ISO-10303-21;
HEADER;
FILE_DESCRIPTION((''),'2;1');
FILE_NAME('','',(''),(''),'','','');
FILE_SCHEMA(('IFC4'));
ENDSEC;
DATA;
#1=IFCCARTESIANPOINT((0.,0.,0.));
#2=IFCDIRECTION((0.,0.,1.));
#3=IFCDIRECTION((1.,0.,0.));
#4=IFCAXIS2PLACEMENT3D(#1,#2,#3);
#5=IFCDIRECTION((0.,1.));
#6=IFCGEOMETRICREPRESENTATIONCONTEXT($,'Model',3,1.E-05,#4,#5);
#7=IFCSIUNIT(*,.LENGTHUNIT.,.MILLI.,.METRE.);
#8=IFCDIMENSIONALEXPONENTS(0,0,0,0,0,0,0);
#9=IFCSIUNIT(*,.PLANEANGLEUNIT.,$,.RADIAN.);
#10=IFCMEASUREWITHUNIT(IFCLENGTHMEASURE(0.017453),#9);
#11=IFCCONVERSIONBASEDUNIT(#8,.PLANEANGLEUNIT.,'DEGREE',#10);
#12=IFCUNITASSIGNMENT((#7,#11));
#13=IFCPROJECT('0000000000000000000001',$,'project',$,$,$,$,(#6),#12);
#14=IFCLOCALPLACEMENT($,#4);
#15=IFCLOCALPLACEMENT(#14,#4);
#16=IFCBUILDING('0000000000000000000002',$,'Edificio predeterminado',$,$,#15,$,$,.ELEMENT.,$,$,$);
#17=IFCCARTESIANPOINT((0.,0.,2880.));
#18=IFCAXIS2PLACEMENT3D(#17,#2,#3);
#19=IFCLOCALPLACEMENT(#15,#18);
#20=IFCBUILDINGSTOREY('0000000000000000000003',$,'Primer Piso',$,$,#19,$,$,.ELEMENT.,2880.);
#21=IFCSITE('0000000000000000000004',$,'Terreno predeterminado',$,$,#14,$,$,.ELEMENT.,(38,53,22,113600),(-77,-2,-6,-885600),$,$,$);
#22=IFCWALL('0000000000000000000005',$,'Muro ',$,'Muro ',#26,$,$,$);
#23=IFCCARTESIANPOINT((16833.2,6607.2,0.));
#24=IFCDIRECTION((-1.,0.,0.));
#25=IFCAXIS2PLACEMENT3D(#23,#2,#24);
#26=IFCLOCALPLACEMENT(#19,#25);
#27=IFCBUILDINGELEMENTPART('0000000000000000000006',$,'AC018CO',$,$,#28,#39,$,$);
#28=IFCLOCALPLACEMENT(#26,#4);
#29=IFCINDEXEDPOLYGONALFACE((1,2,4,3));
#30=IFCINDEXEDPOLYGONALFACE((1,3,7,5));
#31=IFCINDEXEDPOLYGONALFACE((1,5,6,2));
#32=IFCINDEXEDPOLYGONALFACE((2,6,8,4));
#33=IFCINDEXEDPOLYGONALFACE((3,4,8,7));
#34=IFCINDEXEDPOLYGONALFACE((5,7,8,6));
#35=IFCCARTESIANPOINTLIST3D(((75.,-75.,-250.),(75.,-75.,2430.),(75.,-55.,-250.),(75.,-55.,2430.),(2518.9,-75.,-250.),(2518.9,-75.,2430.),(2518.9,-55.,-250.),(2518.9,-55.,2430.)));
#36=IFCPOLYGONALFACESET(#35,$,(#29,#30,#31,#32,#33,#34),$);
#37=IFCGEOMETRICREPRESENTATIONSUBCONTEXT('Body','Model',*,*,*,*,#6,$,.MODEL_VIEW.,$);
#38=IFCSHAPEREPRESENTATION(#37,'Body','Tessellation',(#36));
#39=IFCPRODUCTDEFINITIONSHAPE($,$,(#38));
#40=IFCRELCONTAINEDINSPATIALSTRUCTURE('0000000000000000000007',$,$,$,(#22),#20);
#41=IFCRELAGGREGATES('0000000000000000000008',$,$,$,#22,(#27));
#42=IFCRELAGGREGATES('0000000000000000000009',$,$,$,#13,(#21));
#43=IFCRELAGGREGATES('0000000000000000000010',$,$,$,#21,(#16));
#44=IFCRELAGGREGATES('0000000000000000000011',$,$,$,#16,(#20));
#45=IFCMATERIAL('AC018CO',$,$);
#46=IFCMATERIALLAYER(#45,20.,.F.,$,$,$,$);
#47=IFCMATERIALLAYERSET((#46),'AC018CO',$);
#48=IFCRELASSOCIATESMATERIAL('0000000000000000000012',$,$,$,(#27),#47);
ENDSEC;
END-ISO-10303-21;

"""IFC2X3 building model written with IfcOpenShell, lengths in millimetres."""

from ifc_helpers import new_model, entity, si_unit, converted_unit, direction, frame, origin_with_axes, place, context, subcontext, project, spatial, polyline, outline, extrude, material, layer, layer_set, layer_usage, element, aggregate, save


model = new_model("IFC2X3")

# Units and contexts
model_context = context("Model", 3, precision=1e-05, world=origin_with_axes(), true_north=direction((0.0, 1.0)))
body_context = subcontext(model_context, "Body", "Model", "MODEL_VIEW")
ifc_project = project(units=[si_unit("LENGTHUNIT", "METRE", prefix="MILLI"), converted_unit("PLANEANGLEUNIT", "DEGREE", entity("IfcLengthMeasure", 0.017453), si_unit("PLANEANGLEUNIT", "RADIAN"), dimensions=[0, 0, 0, 0, 0, 0, 0])], contexts=[model_context])

# Site, building, storey
site_placement = place(None, origin_with_axes())
site = spatial("IfcSite", under=ifc_project, at=site_placement, Name="Terreno predeterminado", CompositionType="ELEMENT", RefLatitude=(38, 53, 22, 113600), RefLongitude=(-77, -2, -6, -885600))
building_placement = place(site_placement, origin_with_axes())
building = spatial("IfcBuilding", under=site, at=building_placement, Name="Edificio predeterminado", CompositionType="ELEMENT")
storey_placement = place(building_placement, frame((0.0, 0.0, 2880.0), z_axis=(0.0, 0.0, 1.0), x_axis=(1.0, 0.0, 0.0)))
storey = spatial("IfcBuildingStorey", under=building, at=storey_placement, Name="Primer Piso", CompositionType="ELEMENT", Elevation=2880.0)

# Wall, building element part
wall_1_placement = place(storey_placement, frame((16833.2, 6607.2, 0.0), z_axis=(0.0, 0.0, 1.0), x_axis=(-1.0, 0.0, 0.0)))
wall_1 = element("IfcWall", 1, at=wall_1_placement, inside=storey, Name="Muro ", ObjectType="Muro ")
ifc_material_1 = material(Name="AC018CO")
ifc_layer_1 = layer(ifc_material_1, 20.0, ventilated=False)
ifc_layer_set_1 = layer_set([ifc_layer_1], Name="AC018CO")
ifc_layer_usage_1 = layer_usage(ifc_layer_set_1, "AXIS2", "NEGATIVE", 55.0)
building_element_part_1_placement = place(wall_1_placement, origin_with_axes())
building_element_part_1 = element("IfcBuildingElementPart", 2, at=building_element_part_1_placement, material=ifc_layer_usage_1, Name="AC018CO", context=body_context, shape_type="SweptSolid", body=[
    extrude(outline(polyline([(2518.9, -55.0), (2518.9, -75.0), (75.0, -75.0), (75.0, -55.0), (2518.9, -55.0)])), frame((0.0, 0.0, -250.0), z_axis=(0.0, 0.0, 1.0), x_axis=(1.0, 0.0, 0.0)), (0.0, 0.0, 1.0), 2680.0),
])
aggregate(wall_1, [building_element_part_1])

save(model, "model.ifc")
